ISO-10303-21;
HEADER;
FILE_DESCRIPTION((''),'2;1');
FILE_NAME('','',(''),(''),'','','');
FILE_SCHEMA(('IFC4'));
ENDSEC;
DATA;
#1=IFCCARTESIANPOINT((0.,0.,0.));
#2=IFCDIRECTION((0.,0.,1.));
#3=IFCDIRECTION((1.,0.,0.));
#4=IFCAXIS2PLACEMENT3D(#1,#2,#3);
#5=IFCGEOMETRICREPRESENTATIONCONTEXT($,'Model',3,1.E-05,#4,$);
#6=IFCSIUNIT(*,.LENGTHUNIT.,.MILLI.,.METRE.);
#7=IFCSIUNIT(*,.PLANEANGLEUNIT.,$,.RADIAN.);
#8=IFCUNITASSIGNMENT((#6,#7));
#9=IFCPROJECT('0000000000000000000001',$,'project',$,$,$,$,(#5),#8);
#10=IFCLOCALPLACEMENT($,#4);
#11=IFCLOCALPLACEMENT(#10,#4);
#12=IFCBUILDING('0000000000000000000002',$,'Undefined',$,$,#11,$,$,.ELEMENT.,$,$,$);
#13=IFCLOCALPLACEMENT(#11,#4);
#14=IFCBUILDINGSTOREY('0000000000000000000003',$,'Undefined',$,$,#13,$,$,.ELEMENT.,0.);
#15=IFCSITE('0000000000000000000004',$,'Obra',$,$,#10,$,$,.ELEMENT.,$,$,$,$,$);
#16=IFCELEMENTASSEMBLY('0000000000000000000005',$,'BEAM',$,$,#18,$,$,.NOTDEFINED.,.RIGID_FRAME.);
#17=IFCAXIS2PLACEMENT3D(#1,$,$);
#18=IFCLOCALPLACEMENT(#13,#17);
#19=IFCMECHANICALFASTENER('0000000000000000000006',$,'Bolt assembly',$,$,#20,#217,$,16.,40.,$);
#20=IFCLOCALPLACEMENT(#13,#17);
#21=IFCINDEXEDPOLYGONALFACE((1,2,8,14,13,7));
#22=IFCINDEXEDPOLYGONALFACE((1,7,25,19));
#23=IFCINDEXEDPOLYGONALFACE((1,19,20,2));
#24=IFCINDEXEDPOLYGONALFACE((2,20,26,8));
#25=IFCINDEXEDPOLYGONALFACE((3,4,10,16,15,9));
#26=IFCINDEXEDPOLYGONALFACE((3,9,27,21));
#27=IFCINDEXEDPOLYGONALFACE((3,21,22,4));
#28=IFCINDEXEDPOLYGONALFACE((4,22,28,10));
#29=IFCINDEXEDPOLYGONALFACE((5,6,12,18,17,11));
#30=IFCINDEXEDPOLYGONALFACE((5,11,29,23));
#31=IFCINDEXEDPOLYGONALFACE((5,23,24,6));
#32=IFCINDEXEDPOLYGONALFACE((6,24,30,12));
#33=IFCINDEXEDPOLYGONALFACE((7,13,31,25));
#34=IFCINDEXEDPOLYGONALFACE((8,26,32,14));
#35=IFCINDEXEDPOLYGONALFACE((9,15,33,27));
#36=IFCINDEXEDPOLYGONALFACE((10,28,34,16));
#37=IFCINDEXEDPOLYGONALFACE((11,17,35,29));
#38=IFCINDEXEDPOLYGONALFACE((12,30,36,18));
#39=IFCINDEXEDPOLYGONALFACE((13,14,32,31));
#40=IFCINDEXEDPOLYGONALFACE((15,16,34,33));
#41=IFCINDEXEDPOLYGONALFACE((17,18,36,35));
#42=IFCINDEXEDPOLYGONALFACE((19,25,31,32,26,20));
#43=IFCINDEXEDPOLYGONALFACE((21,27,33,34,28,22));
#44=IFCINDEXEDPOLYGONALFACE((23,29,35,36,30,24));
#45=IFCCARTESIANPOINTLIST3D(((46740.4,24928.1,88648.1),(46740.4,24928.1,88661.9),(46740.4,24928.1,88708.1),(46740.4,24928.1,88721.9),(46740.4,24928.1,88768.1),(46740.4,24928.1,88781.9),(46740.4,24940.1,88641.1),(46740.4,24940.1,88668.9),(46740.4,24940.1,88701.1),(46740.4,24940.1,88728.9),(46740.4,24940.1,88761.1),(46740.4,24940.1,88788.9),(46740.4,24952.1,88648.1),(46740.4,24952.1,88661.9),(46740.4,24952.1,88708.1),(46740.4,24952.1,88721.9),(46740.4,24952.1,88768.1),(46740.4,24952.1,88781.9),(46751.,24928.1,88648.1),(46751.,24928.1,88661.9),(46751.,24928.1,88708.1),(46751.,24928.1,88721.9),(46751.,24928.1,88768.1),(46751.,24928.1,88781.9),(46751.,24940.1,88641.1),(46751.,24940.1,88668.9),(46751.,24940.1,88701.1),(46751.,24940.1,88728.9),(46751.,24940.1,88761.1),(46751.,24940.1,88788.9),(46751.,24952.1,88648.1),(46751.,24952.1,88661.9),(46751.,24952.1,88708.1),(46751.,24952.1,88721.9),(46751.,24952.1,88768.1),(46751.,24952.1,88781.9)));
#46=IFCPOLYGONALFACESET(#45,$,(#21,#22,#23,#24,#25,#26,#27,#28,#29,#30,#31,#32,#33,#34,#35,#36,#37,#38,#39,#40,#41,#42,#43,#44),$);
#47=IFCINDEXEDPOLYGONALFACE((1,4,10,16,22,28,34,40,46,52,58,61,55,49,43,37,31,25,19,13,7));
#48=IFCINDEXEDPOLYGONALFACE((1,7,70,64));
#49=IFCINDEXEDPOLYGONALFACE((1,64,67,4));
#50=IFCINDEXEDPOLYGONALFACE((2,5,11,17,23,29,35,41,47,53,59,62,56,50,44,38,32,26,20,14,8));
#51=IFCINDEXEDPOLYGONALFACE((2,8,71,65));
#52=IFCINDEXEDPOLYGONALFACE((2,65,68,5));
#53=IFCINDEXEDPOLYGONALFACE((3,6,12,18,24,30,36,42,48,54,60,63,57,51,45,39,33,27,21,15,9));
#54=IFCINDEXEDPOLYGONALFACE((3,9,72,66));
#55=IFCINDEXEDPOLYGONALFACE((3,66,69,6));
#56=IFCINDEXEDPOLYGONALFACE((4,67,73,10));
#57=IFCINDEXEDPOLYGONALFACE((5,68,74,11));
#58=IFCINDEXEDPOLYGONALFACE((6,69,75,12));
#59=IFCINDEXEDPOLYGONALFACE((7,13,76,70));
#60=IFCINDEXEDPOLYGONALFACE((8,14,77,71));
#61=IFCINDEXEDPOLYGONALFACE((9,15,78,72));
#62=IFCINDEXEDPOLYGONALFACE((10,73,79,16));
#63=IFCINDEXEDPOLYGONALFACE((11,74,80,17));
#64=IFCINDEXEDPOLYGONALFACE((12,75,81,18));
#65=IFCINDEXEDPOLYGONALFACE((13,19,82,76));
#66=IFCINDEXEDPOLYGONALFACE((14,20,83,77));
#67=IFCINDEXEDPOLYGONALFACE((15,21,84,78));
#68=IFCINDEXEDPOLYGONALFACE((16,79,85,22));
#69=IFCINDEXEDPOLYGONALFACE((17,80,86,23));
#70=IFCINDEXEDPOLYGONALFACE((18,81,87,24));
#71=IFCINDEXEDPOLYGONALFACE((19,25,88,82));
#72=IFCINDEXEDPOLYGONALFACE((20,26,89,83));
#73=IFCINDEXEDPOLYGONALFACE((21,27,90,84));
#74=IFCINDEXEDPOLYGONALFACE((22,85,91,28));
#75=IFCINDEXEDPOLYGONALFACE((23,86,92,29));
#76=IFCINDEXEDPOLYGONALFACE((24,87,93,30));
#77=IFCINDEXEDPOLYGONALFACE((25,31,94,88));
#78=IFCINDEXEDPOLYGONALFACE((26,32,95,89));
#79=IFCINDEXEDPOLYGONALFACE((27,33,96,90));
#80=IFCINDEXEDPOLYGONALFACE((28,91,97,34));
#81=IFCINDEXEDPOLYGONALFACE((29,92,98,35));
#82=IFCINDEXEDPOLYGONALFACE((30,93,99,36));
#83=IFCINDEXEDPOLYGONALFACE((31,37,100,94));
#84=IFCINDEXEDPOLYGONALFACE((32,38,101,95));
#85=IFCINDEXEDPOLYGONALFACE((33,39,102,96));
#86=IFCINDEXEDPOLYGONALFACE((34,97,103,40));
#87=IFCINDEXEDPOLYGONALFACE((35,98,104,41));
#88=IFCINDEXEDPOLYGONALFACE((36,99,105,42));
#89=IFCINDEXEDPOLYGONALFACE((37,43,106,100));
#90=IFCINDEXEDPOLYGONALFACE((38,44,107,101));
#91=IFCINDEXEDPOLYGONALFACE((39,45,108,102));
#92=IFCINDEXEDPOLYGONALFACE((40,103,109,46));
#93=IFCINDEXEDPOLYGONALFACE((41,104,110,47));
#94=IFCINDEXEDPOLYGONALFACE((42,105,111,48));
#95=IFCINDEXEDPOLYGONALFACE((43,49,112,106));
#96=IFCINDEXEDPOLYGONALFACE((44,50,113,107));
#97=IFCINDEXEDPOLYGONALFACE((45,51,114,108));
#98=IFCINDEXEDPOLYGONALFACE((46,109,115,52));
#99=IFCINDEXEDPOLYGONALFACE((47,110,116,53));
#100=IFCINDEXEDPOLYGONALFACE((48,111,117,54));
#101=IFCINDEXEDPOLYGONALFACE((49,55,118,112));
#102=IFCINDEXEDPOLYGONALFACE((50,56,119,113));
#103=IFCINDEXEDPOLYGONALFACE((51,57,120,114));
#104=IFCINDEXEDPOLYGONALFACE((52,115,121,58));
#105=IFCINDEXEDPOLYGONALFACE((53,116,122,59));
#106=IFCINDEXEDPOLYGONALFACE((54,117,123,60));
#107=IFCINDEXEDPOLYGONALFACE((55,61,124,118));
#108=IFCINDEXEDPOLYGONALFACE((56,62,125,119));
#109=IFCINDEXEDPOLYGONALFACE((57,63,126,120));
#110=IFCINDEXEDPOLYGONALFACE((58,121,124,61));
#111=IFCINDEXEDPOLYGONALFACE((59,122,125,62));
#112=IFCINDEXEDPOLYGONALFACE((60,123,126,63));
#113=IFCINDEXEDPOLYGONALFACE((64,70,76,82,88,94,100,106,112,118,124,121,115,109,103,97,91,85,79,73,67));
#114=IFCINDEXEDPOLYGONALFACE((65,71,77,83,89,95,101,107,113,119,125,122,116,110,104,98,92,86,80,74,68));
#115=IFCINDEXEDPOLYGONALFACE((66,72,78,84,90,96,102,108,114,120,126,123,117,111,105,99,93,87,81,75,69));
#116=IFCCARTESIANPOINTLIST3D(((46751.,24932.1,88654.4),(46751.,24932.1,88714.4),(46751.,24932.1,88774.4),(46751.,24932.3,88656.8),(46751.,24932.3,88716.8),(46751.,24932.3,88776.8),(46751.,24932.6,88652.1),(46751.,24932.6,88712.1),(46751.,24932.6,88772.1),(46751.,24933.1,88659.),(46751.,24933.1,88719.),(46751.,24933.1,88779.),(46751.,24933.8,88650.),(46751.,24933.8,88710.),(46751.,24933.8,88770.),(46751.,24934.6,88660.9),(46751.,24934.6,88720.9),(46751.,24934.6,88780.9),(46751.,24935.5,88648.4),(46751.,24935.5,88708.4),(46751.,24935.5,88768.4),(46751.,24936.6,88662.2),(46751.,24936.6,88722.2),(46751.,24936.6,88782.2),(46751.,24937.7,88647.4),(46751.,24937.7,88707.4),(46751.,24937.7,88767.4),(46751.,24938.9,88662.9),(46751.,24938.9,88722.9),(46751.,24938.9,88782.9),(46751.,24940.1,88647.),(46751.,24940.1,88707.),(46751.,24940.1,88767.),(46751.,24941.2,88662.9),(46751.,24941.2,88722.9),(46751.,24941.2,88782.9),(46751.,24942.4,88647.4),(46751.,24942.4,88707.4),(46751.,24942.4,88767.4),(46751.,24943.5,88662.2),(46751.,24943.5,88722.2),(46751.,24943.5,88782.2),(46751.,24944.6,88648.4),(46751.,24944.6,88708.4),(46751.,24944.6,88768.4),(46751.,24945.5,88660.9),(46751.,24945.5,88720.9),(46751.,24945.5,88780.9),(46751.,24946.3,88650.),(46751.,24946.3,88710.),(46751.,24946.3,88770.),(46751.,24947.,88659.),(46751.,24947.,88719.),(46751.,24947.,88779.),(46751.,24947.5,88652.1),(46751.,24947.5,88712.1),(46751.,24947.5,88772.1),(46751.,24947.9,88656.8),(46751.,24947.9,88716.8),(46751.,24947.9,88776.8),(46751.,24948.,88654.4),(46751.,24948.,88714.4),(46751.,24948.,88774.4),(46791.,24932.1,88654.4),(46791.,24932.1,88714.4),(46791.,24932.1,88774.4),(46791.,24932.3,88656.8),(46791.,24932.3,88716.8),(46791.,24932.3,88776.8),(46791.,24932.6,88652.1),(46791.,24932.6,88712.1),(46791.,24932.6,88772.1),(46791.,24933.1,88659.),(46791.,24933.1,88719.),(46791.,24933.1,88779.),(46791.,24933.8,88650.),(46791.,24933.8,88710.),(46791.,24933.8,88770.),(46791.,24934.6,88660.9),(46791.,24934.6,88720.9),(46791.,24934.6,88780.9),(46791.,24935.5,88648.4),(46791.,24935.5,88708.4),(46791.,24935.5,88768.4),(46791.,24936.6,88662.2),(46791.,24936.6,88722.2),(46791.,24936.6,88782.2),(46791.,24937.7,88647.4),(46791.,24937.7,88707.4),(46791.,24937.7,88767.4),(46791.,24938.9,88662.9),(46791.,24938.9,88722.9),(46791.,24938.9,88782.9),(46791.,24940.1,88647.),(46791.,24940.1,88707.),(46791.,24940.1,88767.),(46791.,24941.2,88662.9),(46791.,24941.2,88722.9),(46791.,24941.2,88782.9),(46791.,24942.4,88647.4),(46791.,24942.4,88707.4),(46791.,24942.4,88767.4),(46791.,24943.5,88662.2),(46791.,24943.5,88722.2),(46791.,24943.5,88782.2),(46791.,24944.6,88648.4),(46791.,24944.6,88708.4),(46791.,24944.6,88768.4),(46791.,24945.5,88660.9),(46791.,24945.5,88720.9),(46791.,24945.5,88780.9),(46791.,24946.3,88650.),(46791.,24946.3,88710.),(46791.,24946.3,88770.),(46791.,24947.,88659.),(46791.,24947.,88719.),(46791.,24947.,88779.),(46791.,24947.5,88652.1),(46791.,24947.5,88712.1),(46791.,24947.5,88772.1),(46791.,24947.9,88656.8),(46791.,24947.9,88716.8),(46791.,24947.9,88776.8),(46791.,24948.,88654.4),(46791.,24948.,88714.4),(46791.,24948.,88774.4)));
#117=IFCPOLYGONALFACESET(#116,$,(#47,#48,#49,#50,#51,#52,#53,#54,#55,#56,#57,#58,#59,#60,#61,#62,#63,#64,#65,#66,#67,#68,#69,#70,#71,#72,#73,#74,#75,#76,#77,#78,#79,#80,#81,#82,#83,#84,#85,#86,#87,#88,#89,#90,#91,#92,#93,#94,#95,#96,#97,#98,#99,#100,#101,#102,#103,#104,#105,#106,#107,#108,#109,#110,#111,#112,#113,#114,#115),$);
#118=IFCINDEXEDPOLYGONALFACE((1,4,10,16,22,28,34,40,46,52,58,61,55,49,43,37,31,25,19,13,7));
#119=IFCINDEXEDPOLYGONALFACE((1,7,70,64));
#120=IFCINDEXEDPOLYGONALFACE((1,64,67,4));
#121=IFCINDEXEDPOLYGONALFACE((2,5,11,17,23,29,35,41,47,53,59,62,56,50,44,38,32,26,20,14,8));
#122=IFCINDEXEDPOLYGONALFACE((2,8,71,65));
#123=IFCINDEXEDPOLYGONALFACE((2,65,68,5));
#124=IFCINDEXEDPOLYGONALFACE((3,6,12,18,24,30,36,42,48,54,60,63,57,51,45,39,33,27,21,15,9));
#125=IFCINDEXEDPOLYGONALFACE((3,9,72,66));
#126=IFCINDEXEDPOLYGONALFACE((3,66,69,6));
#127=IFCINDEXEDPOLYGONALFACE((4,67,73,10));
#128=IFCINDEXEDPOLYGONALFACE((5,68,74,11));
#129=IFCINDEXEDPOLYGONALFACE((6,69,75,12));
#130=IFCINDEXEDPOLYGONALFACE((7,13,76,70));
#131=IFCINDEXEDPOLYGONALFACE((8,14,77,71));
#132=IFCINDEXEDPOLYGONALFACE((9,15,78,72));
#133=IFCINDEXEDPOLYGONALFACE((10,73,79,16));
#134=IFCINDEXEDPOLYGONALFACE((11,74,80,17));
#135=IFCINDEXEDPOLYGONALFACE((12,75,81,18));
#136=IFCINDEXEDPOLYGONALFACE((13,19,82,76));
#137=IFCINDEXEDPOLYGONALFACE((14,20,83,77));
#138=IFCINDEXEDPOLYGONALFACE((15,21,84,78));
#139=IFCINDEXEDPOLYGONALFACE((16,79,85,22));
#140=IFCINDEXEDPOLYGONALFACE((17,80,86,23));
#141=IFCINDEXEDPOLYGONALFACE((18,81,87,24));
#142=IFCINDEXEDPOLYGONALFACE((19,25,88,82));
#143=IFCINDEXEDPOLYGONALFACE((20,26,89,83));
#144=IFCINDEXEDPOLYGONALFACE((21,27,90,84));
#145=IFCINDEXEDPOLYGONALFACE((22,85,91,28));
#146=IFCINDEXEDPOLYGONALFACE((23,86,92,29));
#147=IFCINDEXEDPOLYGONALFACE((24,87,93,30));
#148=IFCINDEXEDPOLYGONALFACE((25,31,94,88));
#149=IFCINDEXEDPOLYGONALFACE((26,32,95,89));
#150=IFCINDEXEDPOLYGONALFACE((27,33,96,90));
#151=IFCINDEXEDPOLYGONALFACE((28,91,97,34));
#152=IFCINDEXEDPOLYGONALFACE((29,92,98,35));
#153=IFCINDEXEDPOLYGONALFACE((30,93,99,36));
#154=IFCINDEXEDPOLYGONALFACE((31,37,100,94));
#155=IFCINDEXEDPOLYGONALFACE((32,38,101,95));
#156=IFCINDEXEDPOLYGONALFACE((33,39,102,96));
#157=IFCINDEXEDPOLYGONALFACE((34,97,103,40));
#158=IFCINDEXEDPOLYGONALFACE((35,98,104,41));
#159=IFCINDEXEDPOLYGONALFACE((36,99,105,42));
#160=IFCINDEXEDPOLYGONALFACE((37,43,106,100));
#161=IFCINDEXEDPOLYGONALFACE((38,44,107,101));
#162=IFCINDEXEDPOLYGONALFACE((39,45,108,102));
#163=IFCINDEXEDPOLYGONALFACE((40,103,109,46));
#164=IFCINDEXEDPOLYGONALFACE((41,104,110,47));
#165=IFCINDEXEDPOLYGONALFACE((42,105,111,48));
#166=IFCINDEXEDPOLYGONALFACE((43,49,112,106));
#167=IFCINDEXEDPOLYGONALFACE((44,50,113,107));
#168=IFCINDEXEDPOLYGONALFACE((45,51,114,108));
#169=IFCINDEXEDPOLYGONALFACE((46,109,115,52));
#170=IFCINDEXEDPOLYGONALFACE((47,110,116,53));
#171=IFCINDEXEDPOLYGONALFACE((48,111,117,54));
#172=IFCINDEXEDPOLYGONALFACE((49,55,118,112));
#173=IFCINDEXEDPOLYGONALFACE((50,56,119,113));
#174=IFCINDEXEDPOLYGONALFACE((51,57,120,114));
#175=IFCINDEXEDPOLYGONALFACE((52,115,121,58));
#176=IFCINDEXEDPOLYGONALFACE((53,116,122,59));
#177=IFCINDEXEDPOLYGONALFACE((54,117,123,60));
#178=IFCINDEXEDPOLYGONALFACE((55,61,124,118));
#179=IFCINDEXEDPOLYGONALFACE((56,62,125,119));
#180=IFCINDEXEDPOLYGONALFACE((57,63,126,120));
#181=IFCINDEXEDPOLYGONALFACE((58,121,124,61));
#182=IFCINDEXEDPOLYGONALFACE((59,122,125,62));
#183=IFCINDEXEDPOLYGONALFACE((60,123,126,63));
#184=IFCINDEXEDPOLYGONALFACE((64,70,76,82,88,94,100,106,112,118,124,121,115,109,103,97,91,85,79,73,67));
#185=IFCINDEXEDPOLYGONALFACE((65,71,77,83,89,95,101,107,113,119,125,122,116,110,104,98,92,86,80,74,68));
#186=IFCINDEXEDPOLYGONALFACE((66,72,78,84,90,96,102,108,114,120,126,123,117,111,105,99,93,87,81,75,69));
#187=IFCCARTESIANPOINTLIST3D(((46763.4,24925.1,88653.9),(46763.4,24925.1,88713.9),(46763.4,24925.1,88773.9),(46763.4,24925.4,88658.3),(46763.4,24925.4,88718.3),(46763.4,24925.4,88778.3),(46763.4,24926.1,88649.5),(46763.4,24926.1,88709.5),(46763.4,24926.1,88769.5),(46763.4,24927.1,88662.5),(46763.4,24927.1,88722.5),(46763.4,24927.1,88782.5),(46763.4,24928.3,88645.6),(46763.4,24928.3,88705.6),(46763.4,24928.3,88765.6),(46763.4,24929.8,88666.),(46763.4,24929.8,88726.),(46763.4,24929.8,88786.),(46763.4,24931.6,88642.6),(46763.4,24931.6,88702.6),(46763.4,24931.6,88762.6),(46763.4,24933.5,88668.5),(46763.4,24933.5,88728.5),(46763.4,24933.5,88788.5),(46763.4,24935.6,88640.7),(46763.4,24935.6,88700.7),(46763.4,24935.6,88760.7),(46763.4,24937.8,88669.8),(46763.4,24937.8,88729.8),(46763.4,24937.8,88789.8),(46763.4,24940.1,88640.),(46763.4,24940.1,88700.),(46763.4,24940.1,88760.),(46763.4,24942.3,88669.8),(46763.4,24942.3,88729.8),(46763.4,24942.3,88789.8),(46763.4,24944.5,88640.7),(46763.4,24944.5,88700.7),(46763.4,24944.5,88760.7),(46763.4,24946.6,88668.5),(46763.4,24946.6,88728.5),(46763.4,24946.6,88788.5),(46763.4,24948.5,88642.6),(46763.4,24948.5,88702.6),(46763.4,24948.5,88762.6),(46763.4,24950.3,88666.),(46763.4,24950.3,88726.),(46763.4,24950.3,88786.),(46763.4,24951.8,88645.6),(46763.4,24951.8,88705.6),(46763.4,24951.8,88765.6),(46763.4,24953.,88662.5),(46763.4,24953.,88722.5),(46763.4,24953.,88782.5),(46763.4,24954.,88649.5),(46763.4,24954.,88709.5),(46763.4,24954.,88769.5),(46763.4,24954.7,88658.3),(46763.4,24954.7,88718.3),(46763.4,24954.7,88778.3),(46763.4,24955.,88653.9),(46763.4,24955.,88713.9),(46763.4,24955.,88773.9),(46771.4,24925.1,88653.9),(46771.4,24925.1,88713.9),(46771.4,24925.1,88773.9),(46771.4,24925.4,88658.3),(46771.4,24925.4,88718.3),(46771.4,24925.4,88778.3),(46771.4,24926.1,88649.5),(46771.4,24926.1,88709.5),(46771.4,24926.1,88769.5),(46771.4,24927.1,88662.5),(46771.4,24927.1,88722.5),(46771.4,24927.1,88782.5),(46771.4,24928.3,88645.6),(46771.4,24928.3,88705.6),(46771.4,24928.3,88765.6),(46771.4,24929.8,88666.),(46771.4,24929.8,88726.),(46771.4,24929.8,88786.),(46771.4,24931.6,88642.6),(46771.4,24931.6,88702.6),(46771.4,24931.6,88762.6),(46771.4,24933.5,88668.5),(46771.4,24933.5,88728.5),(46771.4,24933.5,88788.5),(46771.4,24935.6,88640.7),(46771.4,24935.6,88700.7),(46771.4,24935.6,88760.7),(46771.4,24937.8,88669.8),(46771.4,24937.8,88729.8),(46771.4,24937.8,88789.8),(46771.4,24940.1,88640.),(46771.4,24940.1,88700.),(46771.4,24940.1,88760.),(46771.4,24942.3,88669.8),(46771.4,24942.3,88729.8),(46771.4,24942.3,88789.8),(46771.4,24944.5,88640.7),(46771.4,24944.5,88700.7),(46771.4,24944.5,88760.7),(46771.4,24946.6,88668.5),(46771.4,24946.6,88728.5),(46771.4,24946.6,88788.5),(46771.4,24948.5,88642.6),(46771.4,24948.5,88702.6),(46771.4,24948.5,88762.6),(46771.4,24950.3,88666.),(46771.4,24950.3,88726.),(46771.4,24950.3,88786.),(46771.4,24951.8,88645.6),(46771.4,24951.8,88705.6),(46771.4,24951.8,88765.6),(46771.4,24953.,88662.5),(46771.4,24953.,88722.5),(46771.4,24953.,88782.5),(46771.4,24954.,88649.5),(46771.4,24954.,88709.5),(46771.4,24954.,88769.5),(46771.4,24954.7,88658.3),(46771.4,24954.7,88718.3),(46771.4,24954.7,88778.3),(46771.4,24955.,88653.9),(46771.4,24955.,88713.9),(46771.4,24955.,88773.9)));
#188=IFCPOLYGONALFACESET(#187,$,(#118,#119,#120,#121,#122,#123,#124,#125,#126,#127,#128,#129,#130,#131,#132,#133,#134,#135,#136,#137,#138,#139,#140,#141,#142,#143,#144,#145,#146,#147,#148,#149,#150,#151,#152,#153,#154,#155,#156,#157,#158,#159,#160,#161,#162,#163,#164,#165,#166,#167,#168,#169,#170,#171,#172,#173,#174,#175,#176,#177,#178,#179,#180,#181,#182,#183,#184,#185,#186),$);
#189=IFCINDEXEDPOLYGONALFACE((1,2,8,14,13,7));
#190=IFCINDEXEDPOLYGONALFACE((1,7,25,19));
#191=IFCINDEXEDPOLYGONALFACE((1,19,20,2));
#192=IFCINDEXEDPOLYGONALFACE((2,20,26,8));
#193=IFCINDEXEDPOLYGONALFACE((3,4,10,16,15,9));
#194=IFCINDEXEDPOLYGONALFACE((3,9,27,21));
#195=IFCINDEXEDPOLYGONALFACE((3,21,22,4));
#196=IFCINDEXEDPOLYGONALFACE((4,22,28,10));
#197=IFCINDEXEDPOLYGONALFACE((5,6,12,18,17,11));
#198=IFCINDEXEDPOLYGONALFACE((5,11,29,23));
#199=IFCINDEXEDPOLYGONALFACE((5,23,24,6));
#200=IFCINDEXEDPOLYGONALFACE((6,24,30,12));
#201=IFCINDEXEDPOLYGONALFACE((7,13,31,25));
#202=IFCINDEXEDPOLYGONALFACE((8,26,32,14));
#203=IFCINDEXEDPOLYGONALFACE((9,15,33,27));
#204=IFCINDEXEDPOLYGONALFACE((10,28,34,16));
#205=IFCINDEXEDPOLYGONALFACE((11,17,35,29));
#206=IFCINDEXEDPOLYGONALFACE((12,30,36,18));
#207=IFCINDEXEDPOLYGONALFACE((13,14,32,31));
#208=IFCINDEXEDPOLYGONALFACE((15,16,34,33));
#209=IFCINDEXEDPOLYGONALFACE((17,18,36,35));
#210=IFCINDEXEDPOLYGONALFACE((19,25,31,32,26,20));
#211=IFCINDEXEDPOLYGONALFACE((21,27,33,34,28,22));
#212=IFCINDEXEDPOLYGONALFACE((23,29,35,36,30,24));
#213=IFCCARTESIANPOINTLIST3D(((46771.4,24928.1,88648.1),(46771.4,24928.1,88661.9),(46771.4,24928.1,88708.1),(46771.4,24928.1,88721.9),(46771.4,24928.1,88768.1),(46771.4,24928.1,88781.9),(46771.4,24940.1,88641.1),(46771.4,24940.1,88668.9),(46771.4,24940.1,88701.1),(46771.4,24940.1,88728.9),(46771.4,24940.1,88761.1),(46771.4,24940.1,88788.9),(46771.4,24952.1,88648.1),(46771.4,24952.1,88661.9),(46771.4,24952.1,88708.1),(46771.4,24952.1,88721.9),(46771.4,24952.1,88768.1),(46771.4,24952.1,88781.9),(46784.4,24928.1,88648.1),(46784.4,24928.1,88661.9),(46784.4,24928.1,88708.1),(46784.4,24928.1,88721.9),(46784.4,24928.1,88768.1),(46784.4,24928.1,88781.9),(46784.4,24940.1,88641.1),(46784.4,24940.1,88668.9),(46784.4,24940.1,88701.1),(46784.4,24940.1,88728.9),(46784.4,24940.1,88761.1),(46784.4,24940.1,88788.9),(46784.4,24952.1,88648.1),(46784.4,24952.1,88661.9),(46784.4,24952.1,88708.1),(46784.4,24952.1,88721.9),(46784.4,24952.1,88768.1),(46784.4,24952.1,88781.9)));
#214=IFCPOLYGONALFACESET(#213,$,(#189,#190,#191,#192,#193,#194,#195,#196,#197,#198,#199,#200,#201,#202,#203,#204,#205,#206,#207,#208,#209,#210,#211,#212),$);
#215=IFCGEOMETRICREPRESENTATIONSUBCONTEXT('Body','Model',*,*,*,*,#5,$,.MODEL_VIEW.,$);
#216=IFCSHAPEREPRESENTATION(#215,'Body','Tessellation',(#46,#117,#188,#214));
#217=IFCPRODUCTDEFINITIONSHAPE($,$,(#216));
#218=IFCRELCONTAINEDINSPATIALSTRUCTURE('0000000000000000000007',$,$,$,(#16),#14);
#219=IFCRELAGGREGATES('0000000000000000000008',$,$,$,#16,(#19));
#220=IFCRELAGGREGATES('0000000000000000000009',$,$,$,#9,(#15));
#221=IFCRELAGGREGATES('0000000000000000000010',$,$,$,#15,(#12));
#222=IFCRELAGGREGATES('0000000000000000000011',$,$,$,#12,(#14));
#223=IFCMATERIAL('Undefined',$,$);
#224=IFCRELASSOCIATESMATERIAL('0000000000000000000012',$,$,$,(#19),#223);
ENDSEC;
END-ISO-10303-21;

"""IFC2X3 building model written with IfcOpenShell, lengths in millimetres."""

from ifc_helpers import new_model, si_unit, frame, origin_with_axes, origin_2d_with_axis, place, context, subcontext, project, spatial, polyline, circle, outline, extrude, source, transform, mapped, material, element, aggregate, save


model = new_model("IFC2X3")

# Units and contexts
model_context = context("Model", 3, precision=1e-05, world=origin_with_axes())
body_context = subcontext(model_context, "Body", "Model", "MODEL_VIEW")
ifc_project = project(units=[si_unit("LENGTHUNIT", "METRE", prefix="MILLI"), si_unit("PLANEANGLEUNIT", "RADIAN")], contexts=[model_context])

# Site, building, storey
site_placement = place(None, origin_with_axes())
site = spatial("IfcSite", under=ifc_project, at=site_placement, Name="Obra", CompositionType="ELEMENT")
building_placement = place(site_placement, origin_with_axes())
building = spatial("IfcBuilding", under=site, at=building_placement, Name="Undefined", CompositionType="ELEMENT")
storey_placement = place(building_placement, origin_with_axes())
storey = spatial("IfcBuildingStorey", under=building, at=storey_placement, Name="Undefined", CompositionType="ELEMENT", Elevation=0.0)

# Element assembly
ifc_material_1 = material(Name="Undefined")
assembly_1_placement = place(storey_placement, origin_with_axes())
assembly_1 = element("IfcElementAssembly", 1, at=assembly_1_placement, inside=storey, Name="BEAM", AssemblyPlace="NOTDEFINED", PredefinedType="RIGID_FRAME")
shared_shape_1 = source(origin_with_axes(), body_context, "Body", "SweptSolid", [
    extrude(outline(polyline([(13.9, 0.0), (6.9, 12.0), (-6.9, 12.0), (-13.9, 0.0), (-6.9, -12.0), (6.9, -12.0), (13.9, 0.0)])), frame((0.0, -19.7, 0.0), z_axis=(0.0, 1.0, 0.0), x_axis=(1.0, 0.0, 0.0)), (0.0, 0.0, 1.0), 10.6),
    extrude(circle(Radius=8.0, at=origin_2d_with_axis()), frame((0.0, -9.1, 0.0), z_axis=(0.0, 1.0, 0.0), x_axis=(1.0, 0.0, 0.0)), (0.0, 0.0, 1.0), 40.0),
    extrude(circle(Radius=15.0, at=origin_2d_with_axis()), frame((0.0, 3.3, 0.0), z_axis=(0.0, 1.0, 0.0), x_axis=(1.0, 0.0, 0.0)), (0.0, 0.0, 1.0), 8.0),
    extrude(outline(polyline([(13.9, 0.0), (6.9, 12.0), (-6.9, 12.0), (-13.9, 0.0), (-6.9, -12.0), (6.9, -12.0), (13.9, 0.0)])), frame((0.0, 11.3, 0.0), z_axis=(0.0, 1.0, 0.0), x_axis=(1.0, 0.0, 0.0)), (0.0, 0.0, 1.0), 13.0),
])

# Mechanical fastener
mechanical_fastener_1_placement = place(assembly_1_placement, frame((46760.1, 24990.1, 88835.0), z_axis=(0.000002, -1.0, 0.0), x_axis=(0.0, 0.0, -1.0)))
mechanical_fastener_1 = element("IfcMechanicalFastener", 2, at=mechanical_fastener_1_placement, material=ifc_material_1, Name="Bolt assembly", NominalDiameter=16.0, NominalLength=40.0, context=body_context, shape_type="MappedRepresentation", body=[
    mapped(shared_shape_1, transform((60.0, 0.0, 50.0))),
    mapped(shared_shape_1, transform((120.0, 0.0, 50.0))),
    mapped(shared_shape_1, transform((180.0, 0.0, 50.0))),
])
aggregate(assembly_1, [mechanical_fastener_1])

save(model, "model.ifc")
